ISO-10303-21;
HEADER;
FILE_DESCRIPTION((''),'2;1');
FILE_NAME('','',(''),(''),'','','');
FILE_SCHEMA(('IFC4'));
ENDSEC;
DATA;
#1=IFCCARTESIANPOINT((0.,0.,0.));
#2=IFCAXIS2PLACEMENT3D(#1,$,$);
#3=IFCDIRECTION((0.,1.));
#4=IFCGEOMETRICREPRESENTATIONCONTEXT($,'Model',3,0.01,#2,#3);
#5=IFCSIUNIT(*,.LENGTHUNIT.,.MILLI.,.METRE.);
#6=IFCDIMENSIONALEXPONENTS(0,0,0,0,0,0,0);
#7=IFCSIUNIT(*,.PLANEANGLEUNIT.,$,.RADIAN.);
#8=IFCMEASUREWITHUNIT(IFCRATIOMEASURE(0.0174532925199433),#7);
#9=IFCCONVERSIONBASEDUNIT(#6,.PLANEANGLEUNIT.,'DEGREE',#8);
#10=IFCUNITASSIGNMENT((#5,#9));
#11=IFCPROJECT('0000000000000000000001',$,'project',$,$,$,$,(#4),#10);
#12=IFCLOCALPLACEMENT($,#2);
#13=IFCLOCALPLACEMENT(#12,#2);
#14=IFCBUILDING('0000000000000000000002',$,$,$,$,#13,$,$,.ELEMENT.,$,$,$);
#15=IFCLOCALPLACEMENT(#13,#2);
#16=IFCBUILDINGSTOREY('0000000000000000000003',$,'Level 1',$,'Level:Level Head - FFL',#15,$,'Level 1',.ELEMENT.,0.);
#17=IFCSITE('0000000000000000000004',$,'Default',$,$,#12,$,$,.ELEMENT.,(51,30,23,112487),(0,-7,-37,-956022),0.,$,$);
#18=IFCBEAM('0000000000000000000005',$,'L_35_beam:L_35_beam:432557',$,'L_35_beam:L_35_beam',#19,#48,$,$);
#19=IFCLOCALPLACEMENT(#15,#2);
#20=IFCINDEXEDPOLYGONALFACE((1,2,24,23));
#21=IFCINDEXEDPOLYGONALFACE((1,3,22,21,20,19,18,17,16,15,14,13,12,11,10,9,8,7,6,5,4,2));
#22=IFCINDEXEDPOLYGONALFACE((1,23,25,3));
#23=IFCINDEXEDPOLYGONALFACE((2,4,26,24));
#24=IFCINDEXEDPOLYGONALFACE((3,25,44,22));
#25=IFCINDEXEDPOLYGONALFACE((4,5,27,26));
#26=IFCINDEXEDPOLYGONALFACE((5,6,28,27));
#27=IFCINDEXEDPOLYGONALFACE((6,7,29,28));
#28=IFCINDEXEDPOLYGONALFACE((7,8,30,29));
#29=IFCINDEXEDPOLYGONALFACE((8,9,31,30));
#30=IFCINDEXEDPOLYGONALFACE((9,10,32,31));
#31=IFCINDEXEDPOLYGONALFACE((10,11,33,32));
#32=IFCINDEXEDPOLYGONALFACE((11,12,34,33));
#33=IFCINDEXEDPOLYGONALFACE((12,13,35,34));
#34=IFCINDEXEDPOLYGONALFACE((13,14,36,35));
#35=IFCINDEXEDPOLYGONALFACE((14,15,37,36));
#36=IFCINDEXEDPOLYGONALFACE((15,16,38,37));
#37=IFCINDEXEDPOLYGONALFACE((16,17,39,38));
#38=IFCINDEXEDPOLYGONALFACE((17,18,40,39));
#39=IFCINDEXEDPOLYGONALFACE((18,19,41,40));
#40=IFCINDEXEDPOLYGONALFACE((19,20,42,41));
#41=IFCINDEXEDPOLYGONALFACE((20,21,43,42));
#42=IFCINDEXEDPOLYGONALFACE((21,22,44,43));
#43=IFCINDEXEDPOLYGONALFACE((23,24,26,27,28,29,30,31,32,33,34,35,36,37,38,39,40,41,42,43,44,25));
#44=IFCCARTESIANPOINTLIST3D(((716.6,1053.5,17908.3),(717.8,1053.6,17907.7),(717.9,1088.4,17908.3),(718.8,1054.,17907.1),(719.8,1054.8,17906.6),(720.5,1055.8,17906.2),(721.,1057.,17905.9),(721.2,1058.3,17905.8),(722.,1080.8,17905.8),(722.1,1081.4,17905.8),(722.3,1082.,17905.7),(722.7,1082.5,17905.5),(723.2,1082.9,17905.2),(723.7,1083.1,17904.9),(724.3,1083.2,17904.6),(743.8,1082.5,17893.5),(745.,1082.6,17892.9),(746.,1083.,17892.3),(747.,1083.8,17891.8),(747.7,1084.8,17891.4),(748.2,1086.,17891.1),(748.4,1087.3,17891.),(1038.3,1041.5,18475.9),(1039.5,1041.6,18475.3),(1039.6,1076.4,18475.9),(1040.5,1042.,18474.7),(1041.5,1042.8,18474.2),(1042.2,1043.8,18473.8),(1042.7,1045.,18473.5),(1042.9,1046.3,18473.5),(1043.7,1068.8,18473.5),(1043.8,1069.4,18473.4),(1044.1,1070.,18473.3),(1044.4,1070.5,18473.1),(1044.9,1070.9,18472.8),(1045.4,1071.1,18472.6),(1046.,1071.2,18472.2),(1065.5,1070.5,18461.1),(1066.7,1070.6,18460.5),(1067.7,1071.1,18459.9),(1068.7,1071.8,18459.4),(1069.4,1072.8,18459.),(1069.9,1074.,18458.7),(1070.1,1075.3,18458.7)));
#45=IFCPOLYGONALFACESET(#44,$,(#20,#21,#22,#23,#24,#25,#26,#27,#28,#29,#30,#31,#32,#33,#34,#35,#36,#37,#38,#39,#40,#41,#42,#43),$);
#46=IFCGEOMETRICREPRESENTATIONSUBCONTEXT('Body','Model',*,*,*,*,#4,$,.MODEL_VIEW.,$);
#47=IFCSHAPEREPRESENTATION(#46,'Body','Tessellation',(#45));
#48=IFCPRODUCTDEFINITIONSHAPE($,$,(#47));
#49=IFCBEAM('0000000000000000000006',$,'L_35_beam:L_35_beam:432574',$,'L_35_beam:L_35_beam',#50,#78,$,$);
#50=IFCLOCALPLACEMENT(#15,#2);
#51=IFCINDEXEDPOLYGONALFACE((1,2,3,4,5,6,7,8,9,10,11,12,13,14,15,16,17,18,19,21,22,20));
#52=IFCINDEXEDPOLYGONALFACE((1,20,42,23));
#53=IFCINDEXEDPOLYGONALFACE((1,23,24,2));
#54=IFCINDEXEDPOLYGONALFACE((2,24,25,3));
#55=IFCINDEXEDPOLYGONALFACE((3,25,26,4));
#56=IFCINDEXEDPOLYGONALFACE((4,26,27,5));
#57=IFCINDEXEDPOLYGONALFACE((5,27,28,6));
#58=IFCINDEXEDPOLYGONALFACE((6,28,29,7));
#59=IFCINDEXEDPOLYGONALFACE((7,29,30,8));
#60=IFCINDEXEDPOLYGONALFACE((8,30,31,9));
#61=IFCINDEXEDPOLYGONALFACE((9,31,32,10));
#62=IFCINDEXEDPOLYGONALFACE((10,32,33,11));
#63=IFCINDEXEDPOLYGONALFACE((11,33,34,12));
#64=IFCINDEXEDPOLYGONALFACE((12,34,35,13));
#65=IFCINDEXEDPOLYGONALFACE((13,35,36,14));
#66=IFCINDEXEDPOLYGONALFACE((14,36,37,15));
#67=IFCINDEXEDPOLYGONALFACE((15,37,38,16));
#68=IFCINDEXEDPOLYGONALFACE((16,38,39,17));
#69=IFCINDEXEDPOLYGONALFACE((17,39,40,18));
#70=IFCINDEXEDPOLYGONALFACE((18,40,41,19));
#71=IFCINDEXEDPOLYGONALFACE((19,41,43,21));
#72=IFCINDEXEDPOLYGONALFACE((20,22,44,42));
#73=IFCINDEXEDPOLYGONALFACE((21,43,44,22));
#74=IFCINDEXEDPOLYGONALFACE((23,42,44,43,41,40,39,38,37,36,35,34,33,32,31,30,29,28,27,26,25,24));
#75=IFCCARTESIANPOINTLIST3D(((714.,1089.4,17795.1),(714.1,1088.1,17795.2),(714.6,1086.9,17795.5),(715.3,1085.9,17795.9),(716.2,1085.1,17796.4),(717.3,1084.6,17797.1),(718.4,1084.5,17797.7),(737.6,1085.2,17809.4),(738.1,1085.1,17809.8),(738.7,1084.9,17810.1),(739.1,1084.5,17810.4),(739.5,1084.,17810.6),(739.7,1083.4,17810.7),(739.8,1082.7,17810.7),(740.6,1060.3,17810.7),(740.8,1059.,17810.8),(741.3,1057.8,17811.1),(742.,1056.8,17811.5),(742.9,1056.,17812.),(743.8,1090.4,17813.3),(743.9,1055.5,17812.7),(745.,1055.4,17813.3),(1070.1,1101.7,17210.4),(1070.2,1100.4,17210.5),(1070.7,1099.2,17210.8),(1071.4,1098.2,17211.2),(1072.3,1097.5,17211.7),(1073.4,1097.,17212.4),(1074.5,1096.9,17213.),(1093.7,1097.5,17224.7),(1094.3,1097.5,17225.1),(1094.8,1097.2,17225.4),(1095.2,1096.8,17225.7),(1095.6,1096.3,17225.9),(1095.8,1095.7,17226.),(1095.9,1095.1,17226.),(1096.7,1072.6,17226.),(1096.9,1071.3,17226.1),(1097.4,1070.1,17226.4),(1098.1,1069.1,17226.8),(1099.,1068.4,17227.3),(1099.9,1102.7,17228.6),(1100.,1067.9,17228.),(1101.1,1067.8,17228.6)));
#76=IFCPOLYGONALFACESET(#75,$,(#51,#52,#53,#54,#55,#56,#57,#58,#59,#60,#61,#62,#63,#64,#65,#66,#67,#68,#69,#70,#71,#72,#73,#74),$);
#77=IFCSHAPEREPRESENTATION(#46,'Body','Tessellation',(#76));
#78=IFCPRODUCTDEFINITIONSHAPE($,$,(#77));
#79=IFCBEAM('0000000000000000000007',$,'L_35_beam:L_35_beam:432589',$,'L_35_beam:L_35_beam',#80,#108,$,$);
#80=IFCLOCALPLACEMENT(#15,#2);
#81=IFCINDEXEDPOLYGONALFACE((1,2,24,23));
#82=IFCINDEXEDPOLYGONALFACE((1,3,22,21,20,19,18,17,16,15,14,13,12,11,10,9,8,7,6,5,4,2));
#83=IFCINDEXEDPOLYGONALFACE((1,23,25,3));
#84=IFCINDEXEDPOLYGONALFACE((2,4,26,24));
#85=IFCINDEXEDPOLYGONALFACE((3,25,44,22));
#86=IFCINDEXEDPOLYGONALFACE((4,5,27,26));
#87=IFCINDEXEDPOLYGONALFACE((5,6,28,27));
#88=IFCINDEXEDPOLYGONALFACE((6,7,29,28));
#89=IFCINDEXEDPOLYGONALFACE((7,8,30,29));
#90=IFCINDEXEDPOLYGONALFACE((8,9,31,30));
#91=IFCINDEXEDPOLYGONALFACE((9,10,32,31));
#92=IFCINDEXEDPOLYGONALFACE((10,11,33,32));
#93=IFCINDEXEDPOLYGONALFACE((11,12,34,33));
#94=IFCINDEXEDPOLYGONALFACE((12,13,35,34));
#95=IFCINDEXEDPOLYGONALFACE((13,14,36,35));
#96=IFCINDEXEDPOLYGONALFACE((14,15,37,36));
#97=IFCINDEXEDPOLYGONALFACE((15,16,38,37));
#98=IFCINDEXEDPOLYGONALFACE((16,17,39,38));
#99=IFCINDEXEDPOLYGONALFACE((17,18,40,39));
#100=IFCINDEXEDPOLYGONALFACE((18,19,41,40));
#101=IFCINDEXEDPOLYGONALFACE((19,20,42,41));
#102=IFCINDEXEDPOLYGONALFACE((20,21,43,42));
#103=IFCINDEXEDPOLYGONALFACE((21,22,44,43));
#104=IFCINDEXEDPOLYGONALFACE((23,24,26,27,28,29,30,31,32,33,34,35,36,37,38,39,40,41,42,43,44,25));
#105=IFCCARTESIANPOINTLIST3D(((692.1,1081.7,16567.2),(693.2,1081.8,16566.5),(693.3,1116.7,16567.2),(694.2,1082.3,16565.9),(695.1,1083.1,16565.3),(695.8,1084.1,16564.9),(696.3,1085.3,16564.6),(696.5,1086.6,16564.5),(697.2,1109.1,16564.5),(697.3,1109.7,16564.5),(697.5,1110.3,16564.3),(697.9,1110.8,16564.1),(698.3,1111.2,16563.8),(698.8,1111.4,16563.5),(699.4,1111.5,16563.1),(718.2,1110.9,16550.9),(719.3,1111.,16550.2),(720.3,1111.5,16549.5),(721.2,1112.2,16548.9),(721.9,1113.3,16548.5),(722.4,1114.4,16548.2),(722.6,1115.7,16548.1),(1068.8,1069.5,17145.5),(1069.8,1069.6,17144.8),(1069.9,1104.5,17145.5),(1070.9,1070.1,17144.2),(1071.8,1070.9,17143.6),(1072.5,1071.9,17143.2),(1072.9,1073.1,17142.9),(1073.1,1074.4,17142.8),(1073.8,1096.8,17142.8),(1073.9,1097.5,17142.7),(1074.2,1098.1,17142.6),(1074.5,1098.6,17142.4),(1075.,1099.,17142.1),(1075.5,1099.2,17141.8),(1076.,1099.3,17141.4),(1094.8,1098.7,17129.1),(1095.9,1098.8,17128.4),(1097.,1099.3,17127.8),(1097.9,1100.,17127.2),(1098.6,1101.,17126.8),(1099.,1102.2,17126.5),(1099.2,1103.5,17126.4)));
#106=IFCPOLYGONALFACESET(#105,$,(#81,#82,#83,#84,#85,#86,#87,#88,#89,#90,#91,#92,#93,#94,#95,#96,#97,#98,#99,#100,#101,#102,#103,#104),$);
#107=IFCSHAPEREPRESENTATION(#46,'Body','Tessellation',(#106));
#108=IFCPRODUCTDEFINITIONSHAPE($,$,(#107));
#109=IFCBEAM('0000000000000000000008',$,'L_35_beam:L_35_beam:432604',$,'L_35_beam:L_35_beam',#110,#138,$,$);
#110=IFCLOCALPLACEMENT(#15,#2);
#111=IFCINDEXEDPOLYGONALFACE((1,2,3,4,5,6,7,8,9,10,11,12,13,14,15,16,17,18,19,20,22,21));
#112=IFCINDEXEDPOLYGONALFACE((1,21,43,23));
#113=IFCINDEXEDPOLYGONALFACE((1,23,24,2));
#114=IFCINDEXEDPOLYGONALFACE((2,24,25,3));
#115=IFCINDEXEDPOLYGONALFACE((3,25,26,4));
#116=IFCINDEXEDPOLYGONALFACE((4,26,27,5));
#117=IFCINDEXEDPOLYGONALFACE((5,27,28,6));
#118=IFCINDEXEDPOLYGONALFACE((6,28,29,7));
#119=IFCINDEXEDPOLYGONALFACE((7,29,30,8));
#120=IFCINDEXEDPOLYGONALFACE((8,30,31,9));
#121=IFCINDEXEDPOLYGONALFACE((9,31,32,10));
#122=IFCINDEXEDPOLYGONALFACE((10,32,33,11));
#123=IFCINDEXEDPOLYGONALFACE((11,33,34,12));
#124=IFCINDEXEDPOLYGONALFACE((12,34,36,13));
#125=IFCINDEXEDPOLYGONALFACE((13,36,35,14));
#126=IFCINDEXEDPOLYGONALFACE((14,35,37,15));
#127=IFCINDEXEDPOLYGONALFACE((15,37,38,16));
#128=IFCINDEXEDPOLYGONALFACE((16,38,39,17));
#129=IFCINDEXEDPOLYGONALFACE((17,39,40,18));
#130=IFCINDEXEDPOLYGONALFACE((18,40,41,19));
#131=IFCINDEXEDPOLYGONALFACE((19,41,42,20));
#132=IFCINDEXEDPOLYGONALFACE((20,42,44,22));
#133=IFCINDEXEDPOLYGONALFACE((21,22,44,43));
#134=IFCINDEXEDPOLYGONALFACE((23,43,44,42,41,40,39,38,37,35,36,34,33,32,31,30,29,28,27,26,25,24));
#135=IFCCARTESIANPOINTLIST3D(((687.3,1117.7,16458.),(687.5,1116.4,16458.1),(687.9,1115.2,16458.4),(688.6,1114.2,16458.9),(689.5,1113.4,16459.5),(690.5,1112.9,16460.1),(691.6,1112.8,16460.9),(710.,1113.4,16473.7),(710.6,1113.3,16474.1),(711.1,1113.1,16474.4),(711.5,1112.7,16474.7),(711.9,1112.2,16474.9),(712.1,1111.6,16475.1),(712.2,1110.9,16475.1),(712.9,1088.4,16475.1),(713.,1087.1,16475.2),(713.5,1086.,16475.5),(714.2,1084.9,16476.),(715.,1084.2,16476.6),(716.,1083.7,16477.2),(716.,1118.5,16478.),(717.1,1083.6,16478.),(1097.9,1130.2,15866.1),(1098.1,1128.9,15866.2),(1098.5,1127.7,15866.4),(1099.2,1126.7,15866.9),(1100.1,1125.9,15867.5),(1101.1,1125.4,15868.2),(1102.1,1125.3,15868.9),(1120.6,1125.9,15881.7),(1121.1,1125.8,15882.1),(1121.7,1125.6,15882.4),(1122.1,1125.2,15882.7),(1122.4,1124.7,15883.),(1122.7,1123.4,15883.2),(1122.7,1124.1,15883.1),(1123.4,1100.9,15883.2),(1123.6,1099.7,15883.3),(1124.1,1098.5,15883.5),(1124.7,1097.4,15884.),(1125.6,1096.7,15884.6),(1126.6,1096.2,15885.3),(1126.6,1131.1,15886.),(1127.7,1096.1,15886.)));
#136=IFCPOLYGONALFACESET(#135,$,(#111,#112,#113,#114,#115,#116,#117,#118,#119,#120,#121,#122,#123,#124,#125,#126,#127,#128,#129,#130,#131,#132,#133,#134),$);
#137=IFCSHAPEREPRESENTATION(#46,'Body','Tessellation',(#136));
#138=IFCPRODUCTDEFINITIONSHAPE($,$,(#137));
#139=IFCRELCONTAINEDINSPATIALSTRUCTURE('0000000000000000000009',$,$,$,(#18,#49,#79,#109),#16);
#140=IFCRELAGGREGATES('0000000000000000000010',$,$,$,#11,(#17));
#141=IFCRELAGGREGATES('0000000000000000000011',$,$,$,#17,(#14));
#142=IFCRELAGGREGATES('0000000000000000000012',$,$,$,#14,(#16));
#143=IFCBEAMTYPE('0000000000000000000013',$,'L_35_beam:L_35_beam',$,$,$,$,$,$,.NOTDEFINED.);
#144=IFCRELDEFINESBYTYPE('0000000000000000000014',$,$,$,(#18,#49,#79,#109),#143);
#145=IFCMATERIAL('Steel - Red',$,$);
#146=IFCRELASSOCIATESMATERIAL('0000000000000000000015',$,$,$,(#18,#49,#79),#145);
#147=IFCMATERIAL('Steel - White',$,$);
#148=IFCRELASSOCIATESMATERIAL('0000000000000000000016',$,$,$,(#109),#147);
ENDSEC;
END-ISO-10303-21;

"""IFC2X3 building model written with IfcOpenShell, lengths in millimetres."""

from ifc_helpers import new_model, entity, si_unit, converted_unit, direction, frame, frame_2d, origin, place, context, subcontext, project, spatial, polyline, circle_curve, parameter, trimmed, segment, composite_curve, outline, extrude, material, type_object, element, save


model = new_model("IFC2X3")

# Units and contexts
model_context = context("Model", 3, precision=0.01, world=origin(), true_north=direction((0.0, 1.0)))
body_context = subcontext(model_context, "Body", "Model", "MODEL_VIEW")
ifc_project = project(units=[si_unit("LENGTHUNIT", "METRE", prefix="MILLI"), converted_unit("PLANEANGLEUNIT", "DEGREE", entity("IfcRatioMeasure", 0.0174532925199433), si_unit("PLANEANGLEUNIT", "RADIAN"), dimensions=[0, 0, 0, 0, 0, 0, 0])], contexts=[model_context])

# Site, building, storey
site_placement = place(None, origin())
site = spatial("IfcSite", under=ifc_project, at=site_placement, Name="Default", CompositionType="ELEMENT", RefLatitude=(51, 30, 23, 112487), RefLongitude=(0, -7, -37, -956022), RefElevation=0.0)
building_placement = place(site_placement, origin())
building = spatial("IfcBuilding", under=site, at=building_placement, CompositionType="ELEMENT")
storey_placement = place(building_placement, origin())
storey = spatial("IfcBuildingStorey", under=building, at=storey_placement, Name="Level 1", ObjectType="Level:Level Head - FFL", LongName="Level 1", CompositionType="ELEMENT", Elevation=0.0)

# Beams
ifc_material_1 = material(Name="Steel - Red")
ifc_material_2 = material(Name="Steel - White")
beam_type_1 = type_object("IfcBeamType", Name="L_35_beam:L_35_beam", PredefinedType="NOTDEFINED")
beam_1_placement = place(storey_placement, frame((703.1, 1097.0, 17846.1), z_axis=(0.870031, 0.010414, -0.492887), x_axis=(0.492997, -0.018379, 0.869837)))
element("IfcBeam", 1, at=beam_1_placement, inside=storey, type_object=beam_type_1, material=ifc_material_1, Name="L_35_beam:L_35_beam:432557", ObjectType="L_35_beam:L_35_beam", context=body_context, shape_type="SweptSolid", body=[
    extrude(outline(composite_curve([segment(polyline([(-4.3, 6.8), (18.2, 6.8)]), True, "CONTINUOUS"), segment(trimmed(circle_curve(frame_2d((18.2, 11.8), x_axis=(0.0, -1.0)), 5.0), [parameter(0.0)], [parameter(90.0)], True, "PARAMETER"), True, "CONTINUOUS"), segment(polyline([(23.2, 11.8), (-11.8, 11.8)]), True, "CONTINUOUS"), segment(polyline([(-11.8, 11.8), (-11.8, -23.2)]), True, "CONTINUOUS"), segment(trimmed(circle_curve(frame_2d((-11.8, -18.2), x_axis=(0.0, -1.0)), 5.0), [parameter(0.0)], [parameter(90.0)], True, "PARAMETER"), True, "CONTINUOUS"), segment(polyline([(-6.8, -18.2), (-6.8, 4.3)]), True, "CONTINUOUS"), segment(trimmed(circle_curve(frame_2d((-4.3, 4.3), x_axis=(-1.0, 0.0)), 2.5), [parameter(270.0)], [parameter(0.0)], True, "PARAMETER"), False, "CONTINUOUS")], self_intersect=False)), frame((61.6, 19.5, -6.6), z_axis=(1.0, 0.0, 0.0), x_axis=(0.0, 0.04282, 0.999083)), (0.0, 0.0, 1.0), 652.6),
])
beam_2_placement = place(storey_placement, frame((703.1, 1097.0, 17846.1), z_axis=(0.854121, -0.010986, 0.519959), x_axis=(0.520075, 0.018043, -0.85393)))
element("IfcBeam", 2, at=beam_2_placement, inside=storey, type_object=beam_type_1, material=ifc_material_1, Name="L_35_beam:L_35_beam:432574", ObjectType="L_35_beam:L_35_beam", context=body_context, shape_type="SweptSolid", body=[
    extrude(outline(composite_curve([segment(polyline([(-23.2, -11.8), (11.8, -11.8)]), True, "CONTINUOUS"), segment(polyline([(11.8, -11.8), (11.8, 23.2)]), True, "CONTINUOUS"), segment(trimmed(circle_curve(frame_2d((11.8, 18.2), x_axis=(0.0, 1.0)), 5.0), [parameter(0.0)], [parameter(90.0)], True, "PARAMETER"), True, "CONTINUOUS"), segment(polyline([(6.8, 18.2), (6.8, -4.3)]), True, "CONTINUOUS"), segment(trimmed(circle_curve(frame_2d((4.3, -4.3), x_axis=(1.0, 0.0)), 2.5), [parameter(270.0)], [parameter(0.0)], True, "PARAMETER"), False, "CONTINUOUS"), segment(polyline([(4.3, -6.8), (-18.2, -6.8)]), True, "CONTINUOUS"), segment(trimmed(circle_curve(frame_2d((-18.2, -11.8), x_axis=(0.0, 1.0)), 5.0), [parameter(0.0)], [parameter(90.0)], True, "PARAMETER"), True, "CONTINUOUS")], self_intersect=False)), frame((49.1, -19.5, 6.5), z_axis=(1.0, 0.0, 0.0), x_axis=(0.0, 0.040594, 0.999176)), (0.0, 0.0, 1.0), 684.7),
])
beam_3_placement = place(storey_placement, frame((674.8, 1125.3, 16506.4), z_axis=(0.837999, 0.011527, -0.54555), x_axis=(0.545672, -0.017703, 0.837812)))
element("IfcBeam", 3, at=beam_3_placement, inside=storey, type_object=beam_type_1, material=ifc_material_1, Name="L_35_beam:L_35_beam:432589", ObjectType="L_35_beam:L_35_beam", context=body_context, shape_type="SweptSolid", body=[
    extrude(outline(composite_curve([segment(polyline([(-4.3, 6.8), (18.2, 6.8)]), True, "CONTINUOUS"), segment(trimmed(circle_curve(frame_2d((18.2, 11.8), x_axis=(0.0, -1.0)), 5.0), [parameter(0.0)], [parameter(90.0)], True, "PARAMETER"), True, "CONTINUOUS"), segment(polyline([(23.2, 11.8), (-11.8, 11.8)]), True, "CONTINUOUS"), segment(polyline([(-11.8, 11.8), (-11.8, -23.2)]), True, "CONTINUOUS"), segment(trimmed(circle_curve(frame_2d((-11.8, -18.2), x_axis=(0.0, -1.0)), 5.0), [parameter(0.0)], [parameter(90.0)], True, "PARAMETER"), True, "CONTINUOUS"), segment(polyline([(-6.8, -18.2), (-6.8, 4.3)]), True, "CONTINUOUS"), segment(trimmed(circle_curve(frame_2d((-4.3, 4.3), x_axis=(-1.0, 0.0)), 2.5), [parameter(270.0)], [parameter(0.0)], True, "PARAMETER"), False, "CONTINUOUS")], self_intersect=False)), frame((61.2, 19.5, -6.5), z_axis=(1.0, 0.0, 0.0), x_axis=(0.0, 0.038693, 0.999251)), (0.0, 0.0, 1.0), 690.2),
])
beam_4_placement = place(storey_placement, frame((674.8, 1125.3, 16506.4), z_axis=(0.821764, -0.012037, 0.5697), x_axis=(0.569827, 0.01736, -0.821581)))
element("IfcBeam", 4, at=beam_4_placement, inside=storey, type_object=beam_type_1, material=ifc_material_2, Name="L_35_beam:L_35_beam:432604", ObjectType="L_35_beam:L_35_beam", context=body_context, shape_type="SweptSolid", body=[
    extrude(outline(composite_curve([segment(polyline([(-23.2, -11.8), (11.8, -11.8)]), True, "CONTINUOUS"), segment(polyline([(11.8, -11.8), (11.8, 23.2)]), True, "CONTINUOUS"), segment(trimmed(circle_curve(frame_2d((11.8, 18.2), x_axis=(0.0, 1.0)), 5.0), [parameter(0.0)], [parameter(90.0)], True, "PARAMETER"), True, "CONTINUOUS"), segment(polyline([(6.8, 18.2), (6.8, -4.3)]), True, "CONTINUOUS"), segment(trimmed(circle_curve(frame_2d((4.3, -4.3), x_axis=(1.0, 0.0)), 2.5), [parameter(270.0)], [parameter(0.0)], True, "PARAMETER"), False, "CONTINUOUS"), segment(polyline([(4.3, -6.8), (-18.2, -6.8)]), True, "CONTINUOUS"), segment(trimmed(circle_curve(frame_2d((-18.2, -11.8), x_axis=(0.0, 1.0)), 5.0), [parameter(0.0)], [parameter(90.0)], True, "PARAMETER"), True, "CONTINUOUS")], self_intersect=False)), frame((46.8, -19.6, 6.4), z_axis=(1.0, 0.0, 0.0), x_axis=(0.0, 0.037055, 0.999313)), (0.0, 0.0, 1.0), 720.5),
])

save(model, "model.ifc")
